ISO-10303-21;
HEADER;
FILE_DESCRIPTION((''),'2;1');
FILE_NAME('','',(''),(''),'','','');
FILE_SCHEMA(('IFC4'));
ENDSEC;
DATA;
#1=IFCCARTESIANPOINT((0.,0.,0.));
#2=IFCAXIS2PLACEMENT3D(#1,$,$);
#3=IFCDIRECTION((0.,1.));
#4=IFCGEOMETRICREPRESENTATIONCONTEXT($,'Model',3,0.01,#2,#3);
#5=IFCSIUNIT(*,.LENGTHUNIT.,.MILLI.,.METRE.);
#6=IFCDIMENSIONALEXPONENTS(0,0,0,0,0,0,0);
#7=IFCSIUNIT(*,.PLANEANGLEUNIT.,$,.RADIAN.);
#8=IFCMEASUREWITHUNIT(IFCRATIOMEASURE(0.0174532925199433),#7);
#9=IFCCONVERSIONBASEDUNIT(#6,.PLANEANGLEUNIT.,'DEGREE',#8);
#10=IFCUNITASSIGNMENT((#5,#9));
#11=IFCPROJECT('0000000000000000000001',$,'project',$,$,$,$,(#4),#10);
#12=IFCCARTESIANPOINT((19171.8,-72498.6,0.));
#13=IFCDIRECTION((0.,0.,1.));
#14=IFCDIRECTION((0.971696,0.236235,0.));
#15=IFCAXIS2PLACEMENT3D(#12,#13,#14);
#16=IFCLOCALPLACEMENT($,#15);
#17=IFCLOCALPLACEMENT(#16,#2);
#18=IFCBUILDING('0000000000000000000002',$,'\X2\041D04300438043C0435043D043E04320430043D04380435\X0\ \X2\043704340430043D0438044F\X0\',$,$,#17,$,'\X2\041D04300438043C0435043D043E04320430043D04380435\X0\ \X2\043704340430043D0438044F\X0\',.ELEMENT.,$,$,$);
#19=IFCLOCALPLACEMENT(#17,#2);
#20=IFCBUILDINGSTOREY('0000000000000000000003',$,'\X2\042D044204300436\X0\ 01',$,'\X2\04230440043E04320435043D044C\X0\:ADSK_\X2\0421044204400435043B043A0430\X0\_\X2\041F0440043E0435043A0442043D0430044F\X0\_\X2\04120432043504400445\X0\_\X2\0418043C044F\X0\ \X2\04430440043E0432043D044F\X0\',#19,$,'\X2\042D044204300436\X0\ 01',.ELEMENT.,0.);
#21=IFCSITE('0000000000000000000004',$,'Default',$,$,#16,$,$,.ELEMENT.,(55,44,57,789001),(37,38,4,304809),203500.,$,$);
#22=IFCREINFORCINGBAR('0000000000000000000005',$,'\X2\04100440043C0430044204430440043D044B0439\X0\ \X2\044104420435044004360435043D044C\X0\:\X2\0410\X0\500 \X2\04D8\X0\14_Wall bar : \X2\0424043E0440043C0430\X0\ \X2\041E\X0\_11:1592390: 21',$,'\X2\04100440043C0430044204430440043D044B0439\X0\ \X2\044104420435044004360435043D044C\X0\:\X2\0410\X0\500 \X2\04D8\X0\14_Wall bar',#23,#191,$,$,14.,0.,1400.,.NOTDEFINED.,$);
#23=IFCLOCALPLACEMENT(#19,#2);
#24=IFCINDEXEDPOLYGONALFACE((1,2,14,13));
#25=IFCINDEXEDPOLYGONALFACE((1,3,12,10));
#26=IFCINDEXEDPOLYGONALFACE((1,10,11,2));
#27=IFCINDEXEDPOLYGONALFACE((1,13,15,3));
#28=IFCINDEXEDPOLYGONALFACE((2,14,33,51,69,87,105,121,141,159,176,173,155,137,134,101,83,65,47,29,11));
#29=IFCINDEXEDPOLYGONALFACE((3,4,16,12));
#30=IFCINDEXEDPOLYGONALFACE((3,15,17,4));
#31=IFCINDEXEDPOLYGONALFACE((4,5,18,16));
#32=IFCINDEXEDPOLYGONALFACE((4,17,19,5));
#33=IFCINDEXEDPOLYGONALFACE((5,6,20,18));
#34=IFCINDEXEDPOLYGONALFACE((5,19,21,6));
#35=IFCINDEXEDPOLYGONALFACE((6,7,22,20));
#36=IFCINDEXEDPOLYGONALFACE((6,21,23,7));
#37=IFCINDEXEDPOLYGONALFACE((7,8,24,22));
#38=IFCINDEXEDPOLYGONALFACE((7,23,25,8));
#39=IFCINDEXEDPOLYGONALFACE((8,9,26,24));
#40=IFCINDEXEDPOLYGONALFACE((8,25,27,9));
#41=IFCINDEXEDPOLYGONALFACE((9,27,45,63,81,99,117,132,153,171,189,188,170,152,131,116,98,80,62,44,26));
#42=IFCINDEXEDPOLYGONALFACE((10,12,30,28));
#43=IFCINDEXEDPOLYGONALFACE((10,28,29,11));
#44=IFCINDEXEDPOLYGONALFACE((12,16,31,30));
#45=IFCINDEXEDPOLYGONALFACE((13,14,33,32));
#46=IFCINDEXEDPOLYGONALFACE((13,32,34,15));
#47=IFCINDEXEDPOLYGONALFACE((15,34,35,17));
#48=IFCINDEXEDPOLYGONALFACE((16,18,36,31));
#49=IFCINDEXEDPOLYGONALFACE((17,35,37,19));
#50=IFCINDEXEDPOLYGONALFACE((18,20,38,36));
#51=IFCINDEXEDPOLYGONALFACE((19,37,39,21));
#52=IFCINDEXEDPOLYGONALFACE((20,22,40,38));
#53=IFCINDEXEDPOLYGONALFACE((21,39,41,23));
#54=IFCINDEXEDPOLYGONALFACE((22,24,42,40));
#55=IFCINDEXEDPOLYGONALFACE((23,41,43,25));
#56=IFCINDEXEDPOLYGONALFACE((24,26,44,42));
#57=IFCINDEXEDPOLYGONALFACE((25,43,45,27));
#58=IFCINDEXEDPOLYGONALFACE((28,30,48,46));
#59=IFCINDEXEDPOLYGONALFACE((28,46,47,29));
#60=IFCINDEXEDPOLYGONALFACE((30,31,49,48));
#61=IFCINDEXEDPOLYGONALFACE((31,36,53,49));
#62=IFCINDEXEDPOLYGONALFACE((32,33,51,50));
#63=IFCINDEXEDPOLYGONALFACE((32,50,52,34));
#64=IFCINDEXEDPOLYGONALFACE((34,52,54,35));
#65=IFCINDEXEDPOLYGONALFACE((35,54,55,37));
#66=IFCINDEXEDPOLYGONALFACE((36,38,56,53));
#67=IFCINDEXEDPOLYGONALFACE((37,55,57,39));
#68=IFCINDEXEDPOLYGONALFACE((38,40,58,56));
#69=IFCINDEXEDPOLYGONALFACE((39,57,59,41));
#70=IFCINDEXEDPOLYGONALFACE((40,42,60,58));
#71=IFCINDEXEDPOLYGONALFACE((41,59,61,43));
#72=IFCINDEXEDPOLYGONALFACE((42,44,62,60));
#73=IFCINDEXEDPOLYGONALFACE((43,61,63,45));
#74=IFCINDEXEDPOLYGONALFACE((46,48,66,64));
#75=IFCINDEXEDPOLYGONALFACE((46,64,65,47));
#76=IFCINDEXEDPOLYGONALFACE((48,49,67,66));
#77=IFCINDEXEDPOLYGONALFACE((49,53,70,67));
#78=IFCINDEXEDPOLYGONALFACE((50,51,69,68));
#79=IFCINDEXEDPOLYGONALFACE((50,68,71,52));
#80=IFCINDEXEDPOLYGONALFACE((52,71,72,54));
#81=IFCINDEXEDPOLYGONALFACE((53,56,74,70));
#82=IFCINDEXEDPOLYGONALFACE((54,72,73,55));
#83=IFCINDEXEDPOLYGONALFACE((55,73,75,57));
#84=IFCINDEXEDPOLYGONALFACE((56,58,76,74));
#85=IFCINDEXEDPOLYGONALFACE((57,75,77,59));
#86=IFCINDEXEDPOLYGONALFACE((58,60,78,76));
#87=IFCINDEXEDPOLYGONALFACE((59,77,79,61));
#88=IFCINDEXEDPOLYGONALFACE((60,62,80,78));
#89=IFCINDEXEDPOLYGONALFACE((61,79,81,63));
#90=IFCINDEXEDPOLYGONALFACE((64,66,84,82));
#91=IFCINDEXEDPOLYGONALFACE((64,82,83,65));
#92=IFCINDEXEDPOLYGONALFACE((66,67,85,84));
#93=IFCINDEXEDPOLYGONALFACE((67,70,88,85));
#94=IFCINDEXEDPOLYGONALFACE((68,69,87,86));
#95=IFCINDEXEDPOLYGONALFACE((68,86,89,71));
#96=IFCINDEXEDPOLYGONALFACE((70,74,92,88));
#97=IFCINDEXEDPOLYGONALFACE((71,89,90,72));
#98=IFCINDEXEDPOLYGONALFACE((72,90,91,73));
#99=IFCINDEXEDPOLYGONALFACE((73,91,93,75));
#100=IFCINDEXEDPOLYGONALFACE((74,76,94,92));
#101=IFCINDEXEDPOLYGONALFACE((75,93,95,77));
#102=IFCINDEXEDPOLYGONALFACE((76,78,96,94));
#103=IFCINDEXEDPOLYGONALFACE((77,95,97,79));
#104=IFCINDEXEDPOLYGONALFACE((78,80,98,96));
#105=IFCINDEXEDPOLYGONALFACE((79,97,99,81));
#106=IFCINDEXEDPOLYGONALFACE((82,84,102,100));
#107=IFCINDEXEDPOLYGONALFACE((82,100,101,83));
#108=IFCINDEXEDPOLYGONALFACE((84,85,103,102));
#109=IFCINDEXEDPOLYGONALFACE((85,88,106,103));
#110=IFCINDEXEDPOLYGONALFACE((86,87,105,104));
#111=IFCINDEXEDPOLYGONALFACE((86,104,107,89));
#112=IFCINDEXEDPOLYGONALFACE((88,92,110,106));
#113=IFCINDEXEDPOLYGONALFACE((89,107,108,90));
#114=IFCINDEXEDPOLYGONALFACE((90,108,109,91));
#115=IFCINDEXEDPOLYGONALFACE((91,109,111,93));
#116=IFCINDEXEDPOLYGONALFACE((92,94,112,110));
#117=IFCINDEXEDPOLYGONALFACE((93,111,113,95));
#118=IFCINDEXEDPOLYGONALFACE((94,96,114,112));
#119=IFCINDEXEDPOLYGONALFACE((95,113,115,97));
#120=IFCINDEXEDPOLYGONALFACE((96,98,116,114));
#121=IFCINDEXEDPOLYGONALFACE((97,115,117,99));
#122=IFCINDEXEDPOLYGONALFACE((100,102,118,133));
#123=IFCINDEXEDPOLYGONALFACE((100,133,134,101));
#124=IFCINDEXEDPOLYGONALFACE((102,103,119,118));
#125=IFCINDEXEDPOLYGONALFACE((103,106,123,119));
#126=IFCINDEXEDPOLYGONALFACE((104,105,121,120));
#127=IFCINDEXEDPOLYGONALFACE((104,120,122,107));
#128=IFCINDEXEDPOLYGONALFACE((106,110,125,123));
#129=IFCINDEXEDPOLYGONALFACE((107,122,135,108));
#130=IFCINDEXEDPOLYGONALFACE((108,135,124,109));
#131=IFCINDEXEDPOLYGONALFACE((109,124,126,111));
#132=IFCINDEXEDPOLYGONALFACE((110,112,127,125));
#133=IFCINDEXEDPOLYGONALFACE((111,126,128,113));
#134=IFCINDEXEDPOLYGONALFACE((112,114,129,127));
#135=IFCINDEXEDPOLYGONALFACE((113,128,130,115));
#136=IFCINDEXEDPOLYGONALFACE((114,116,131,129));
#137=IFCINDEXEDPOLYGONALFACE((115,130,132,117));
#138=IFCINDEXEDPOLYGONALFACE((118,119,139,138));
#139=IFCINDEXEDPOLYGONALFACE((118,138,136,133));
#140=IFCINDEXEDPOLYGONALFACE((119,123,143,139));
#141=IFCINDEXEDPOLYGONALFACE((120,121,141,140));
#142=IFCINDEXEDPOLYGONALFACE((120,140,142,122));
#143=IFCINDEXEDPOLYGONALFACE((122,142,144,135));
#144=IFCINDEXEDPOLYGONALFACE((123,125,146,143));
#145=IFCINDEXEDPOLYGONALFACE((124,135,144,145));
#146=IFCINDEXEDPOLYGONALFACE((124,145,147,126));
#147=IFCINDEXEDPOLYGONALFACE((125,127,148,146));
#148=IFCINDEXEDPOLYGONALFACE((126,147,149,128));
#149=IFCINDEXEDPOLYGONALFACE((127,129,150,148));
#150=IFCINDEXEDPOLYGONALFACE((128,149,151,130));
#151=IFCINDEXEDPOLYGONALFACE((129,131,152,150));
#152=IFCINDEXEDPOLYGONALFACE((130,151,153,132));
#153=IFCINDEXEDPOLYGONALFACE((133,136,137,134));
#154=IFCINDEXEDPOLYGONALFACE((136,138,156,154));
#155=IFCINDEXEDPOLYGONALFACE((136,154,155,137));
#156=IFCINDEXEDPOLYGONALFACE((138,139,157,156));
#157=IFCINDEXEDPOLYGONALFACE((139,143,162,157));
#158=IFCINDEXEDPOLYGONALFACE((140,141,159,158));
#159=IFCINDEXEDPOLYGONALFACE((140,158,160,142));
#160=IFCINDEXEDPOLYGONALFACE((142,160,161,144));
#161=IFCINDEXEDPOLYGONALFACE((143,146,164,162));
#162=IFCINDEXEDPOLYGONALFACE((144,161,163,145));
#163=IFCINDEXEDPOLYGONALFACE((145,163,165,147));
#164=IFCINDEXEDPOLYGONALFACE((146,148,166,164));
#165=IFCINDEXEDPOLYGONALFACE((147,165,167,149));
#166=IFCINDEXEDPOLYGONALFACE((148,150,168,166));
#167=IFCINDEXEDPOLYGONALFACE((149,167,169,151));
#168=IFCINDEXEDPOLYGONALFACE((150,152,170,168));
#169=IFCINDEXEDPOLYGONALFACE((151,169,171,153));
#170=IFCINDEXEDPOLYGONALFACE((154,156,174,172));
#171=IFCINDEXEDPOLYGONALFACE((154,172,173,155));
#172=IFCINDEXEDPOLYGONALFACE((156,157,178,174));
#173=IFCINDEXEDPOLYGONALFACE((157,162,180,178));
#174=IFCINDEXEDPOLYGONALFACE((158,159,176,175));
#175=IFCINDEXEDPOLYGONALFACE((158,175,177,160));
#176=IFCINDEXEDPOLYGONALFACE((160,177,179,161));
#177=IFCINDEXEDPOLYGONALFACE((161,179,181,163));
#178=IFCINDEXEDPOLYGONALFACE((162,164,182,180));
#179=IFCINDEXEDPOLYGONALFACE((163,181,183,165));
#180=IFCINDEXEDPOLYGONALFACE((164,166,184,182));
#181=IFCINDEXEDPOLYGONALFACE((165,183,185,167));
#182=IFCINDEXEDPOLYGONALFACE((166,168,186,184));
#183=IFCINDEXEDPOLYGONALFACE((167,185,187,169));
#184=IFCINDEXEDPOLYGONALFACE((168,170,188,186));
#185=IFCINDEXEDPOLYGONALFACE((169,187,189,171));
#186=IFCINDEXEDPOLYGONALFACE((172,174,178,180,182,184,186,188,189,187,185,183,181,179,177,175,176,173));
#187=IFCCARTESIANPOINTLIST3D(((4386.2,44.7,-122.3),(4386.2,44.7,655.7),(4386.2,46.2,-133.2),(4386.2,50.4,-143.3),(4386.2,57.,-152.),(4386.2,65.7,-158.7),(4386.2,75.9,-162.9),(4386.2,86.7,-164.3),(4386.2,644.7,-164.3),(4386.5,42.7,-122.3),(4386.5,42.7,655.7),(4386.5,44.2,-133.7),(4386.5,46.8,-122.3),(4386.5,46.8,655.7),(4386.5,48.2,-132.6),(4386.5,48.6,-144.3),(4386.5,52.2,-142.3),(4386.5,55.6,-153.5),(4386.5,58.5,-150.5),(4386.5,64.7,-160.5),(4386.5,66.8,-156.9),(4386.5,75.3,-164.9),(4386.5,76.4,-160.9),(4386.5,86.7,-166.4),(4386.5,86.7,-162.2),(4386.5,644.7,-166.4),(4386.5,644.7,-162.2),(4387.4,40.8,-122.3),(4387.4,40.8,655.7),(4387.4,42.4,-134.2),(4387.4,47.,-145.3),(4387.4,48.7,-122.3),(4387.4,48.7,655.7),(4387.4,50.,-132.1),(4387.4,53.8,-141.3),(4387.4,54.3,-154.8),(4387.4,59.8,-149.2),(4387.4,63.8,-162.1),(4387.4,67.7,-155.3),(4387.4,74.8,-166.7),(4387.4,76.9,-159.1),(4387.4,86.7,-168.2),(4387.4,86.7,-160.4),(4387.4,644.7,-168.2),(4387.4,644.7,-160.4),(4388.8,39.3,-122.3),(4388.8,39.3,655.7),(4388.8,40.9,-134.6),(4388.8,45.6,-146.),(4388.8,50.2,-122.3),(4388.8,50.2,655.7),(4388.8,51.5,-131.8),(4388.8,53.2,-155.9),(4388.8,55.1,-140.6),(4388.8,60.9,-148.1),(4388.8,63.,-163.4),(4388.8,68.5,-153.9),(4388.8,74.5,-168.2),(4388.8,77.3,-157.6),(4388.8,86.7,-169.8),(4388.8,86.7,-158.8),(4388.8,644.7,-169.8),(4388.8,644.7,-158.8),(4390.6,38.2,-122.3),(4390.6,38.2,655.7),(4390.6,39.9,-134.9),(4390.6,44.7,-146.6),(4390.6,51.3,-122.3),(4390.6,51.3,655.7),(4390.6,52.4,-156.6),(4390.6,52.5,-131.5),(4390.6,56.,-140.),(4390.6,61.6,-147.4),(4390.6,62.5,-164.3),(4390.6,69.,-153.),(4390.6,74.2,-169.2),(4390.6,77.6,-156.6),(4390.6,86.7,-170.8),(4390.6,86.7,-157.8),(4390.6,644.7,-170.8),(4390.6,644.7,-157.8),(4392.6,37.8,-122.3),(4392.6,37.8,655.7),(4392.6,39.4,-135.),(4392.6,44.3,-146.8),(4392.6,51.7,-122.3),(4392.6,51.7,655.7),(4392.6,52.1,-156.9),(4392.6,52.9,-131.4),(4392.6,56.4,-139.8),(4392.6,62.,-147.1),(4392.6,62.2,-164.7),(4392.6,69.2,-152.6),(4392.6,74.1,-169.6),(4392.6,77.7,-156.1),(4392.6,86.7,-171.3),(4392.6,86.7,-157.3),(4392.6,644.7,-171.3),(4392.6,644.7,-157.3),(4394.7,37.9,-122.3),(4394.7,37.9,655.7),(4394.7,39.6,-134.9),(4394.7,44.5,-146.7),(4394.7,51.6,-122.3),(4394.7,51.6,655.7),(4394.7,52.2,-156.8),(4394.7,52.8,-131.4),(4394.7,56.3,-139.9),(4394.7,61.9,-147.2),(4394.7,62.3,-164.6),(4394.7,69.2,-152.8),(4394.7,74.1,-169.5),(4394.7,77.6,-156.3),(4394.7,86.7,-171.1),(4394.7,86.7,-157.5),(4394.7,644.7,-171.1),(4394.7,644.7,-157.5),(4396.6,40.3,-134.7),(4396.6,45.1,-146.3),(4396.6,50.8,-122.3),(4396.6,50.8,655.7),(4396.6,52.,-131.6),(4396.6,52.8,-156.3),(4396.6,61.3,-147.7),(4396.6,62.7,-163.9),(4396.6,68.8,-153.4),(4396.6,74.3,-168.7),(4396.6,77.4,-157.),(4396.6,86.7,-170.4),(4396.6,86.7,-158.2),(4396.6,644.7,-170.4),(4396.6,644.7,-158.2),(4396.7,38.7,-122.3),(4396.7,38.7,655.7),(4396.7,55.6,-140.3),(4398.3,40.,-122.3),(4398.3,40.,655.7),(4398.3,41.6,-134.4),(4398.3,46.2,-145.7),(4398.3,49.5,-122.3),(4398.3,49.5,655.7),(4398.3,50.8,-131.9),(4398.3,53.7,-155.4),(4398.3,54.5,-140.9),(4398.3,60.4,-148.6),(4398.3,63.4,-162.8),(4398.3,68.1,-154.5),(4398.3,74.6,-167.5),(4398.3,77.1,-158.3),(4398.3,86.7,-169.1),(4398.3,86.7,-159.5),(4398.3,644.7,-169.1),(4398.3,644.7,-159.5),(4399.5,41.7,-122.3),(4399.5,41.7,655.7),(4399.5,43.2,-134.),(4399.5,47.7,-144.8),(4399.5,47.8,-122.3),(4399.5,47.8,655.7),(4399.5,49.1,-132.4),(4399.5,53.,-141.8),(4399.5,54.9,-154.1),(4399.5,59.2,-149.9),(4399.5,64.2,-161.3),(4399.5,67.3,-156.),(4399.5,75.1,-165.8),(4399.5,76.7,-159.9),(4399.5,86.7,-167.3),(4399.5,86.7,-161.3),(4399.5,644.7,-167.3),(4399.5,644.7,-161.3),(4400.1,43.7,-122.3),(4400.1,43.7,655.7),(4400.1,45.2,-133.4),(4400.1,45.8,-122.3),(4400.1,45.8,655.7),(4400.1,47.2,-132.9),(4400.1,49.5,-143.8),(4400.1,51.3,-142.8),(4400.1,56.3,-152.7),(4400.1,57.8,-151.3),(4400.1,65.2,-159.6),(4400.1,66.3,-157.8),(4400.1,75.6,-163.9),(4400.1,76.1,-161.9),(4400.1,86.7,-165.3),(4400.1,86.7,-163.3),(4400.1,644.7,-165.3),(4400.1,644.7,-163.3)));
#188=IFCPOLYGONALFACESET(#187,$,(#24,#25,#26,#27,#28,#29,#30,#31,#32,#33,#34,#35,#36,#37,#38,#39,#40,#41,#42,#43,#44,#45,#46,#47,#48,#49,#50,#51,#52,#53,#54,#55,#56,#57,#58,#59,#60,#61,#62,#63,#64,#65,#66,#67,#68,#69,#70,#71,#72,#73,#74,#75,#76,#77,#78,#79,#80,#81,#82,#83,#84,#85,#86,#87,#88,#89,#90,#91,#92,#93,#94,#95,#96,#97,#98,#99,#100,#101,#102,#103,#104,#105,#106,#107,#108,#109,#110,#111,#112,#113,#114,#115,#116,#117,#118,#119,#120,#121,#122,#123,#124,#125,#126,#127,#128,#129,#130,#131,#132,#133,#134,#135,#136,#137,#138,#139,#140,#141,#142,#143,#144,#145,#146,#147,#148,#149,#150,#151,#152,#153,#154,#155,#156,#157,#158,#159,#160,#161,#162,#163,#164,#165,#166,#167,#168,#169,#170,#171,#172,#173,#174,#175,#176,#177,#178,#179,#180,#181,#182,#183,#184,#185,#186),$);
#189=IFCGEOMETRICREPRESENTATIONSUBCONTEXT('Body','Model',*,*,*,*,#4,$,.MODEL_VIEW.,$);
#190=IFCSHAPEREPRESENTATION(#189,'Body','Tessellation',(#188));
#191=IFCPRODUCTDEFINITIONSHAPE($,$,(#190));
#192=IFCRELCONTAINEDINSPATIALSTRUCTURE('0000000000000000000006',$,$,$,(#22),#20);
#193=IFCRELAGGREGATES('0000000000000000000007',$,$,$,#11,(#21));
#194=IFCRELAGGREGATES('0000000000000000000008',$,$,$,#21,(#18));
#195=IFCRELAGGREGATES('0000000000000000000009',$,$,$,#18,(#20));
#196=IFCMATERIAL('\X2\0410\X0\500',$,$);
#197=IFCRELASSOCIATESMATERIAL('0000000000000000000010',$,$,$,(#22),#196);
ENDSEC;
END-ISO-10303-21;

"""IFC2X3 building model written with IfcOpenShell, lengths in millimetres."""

from ifc_helpers import new_model, entity, si_unit, converted_unit, direction, frame, origin, place, context, subcontext, project, spatial, material, element, save


model = new_model("IFC2X3")

# Units and contexts
model_context = context("Model", 3, precision=0.01, world=origin(), true_north=direction((0.0, 1.0)))
body_context = subcontext(model_context, "Body", "Model", "MODEL_VIEW")
ifc_project = project(units=[si_unit("LENGTHUNIT", "METRE", prefix="MILLI"), converted_unit("PLANEANGLEUNIT", "DEGREE", entity("IfcRatioMeasure", 0.0174532925199433), si_unit("PLANEANGLEUNIT", "RADIAN"), dimensions=[0, 0, 0, 0, 0, 0, 0])], contexts=[model_context])

# Site, building, storey
site_placement = place(None, frame((19171.8, -72498.6, 0.0), z_axis=(0.0, 0.0, 1.0), x_axis=(0.971696, 0.236235, 0.0)))
site = spatial("IfcSite", under=ifc_project, at=site_placement, Name="Default", CompositionType="ELEMENT", RefLatitude=(55, 44, 57, 789001), RefLongitude=(37, 38, 4, 304809), RefElevation=203500.0)
building_placement = place(site_placement, origin())
building = spatial("IfcBuilding", under=site, at=building_placement, Name="Наименование здания", LongName="Наименование здания", CompositionType="ELEMENT")
storey_placement = place(building_placement, origin())
storey = spatial("IfcBuildingStorey", under=building, at=storey_placement, Name="Этаж 01", ObjectType="Уровень:ADSK_Стрелка_Проектная_Вверх_Имя уровня", LongName="Этаж 01", CompositionType="ELEMENT", Elevation=0.0)

# Reinforcing bar
ifc_material = material(Name="А500")
placement = place(storey_placement, origin())
element("IfcReinforcingBar", 1, at=placement, inside=storey, material=ifc_material, Name="Арматурный стержень:А500 Ә14_Wall bar : Форма О_11:1592390: 21", ObjectType="Арматурный стержень:А500 Ә14_Wall bar", BarLength=1400.0, BarRole="NOTDEFINED", CrossSectionArea=0.0, NominalDiameter=14.0, context=body_context, shape_type="AdvancedSweptSolid", body=[
    entity("IfcSweptDiskSolid", entity("IfcCompositeCurve", [entity("IfcCompositeCurveSegment", "CONTINUOUS", True, entity("IfcPolyline", [entity("IfcCartesianPoint", [4393.1, 44.7, 655.7]), entity("IfcCartesianPoint", [4393.1, 44.7, -122.3])])), entity("IfcCompositeCurveSegment", "CONTINUOUS", True, entity("IfcTrimmedCurve", entity("IfcCircle", entity("IfcAxis2Placement3D", entity("IfcCartesianPoint", [4393.1, 86.7, -122.3]), entity("IfcDirection", [1.0, 0.0, 0.0]), entity("IfcDirection", [0.0, 0.0, -1.0])), 42.0), [entity("IfcParameterValue", 270.0)], [entity("IfcParameterValue", 360.0)], True, "PARAMETER")), entity("IfcCompositeCurveSegment", "CONTINUOUS", True, entity("IfcPolyline", [entity("IfcCartesianPoint", [4393.1, 86.7, -164.3]), entity("IfcCartesianPoint", [4393.1, 644.7, -164.3])]))], False), 7.0, None, 0.0, 92.0),
])

save(model, "model.ifc")
